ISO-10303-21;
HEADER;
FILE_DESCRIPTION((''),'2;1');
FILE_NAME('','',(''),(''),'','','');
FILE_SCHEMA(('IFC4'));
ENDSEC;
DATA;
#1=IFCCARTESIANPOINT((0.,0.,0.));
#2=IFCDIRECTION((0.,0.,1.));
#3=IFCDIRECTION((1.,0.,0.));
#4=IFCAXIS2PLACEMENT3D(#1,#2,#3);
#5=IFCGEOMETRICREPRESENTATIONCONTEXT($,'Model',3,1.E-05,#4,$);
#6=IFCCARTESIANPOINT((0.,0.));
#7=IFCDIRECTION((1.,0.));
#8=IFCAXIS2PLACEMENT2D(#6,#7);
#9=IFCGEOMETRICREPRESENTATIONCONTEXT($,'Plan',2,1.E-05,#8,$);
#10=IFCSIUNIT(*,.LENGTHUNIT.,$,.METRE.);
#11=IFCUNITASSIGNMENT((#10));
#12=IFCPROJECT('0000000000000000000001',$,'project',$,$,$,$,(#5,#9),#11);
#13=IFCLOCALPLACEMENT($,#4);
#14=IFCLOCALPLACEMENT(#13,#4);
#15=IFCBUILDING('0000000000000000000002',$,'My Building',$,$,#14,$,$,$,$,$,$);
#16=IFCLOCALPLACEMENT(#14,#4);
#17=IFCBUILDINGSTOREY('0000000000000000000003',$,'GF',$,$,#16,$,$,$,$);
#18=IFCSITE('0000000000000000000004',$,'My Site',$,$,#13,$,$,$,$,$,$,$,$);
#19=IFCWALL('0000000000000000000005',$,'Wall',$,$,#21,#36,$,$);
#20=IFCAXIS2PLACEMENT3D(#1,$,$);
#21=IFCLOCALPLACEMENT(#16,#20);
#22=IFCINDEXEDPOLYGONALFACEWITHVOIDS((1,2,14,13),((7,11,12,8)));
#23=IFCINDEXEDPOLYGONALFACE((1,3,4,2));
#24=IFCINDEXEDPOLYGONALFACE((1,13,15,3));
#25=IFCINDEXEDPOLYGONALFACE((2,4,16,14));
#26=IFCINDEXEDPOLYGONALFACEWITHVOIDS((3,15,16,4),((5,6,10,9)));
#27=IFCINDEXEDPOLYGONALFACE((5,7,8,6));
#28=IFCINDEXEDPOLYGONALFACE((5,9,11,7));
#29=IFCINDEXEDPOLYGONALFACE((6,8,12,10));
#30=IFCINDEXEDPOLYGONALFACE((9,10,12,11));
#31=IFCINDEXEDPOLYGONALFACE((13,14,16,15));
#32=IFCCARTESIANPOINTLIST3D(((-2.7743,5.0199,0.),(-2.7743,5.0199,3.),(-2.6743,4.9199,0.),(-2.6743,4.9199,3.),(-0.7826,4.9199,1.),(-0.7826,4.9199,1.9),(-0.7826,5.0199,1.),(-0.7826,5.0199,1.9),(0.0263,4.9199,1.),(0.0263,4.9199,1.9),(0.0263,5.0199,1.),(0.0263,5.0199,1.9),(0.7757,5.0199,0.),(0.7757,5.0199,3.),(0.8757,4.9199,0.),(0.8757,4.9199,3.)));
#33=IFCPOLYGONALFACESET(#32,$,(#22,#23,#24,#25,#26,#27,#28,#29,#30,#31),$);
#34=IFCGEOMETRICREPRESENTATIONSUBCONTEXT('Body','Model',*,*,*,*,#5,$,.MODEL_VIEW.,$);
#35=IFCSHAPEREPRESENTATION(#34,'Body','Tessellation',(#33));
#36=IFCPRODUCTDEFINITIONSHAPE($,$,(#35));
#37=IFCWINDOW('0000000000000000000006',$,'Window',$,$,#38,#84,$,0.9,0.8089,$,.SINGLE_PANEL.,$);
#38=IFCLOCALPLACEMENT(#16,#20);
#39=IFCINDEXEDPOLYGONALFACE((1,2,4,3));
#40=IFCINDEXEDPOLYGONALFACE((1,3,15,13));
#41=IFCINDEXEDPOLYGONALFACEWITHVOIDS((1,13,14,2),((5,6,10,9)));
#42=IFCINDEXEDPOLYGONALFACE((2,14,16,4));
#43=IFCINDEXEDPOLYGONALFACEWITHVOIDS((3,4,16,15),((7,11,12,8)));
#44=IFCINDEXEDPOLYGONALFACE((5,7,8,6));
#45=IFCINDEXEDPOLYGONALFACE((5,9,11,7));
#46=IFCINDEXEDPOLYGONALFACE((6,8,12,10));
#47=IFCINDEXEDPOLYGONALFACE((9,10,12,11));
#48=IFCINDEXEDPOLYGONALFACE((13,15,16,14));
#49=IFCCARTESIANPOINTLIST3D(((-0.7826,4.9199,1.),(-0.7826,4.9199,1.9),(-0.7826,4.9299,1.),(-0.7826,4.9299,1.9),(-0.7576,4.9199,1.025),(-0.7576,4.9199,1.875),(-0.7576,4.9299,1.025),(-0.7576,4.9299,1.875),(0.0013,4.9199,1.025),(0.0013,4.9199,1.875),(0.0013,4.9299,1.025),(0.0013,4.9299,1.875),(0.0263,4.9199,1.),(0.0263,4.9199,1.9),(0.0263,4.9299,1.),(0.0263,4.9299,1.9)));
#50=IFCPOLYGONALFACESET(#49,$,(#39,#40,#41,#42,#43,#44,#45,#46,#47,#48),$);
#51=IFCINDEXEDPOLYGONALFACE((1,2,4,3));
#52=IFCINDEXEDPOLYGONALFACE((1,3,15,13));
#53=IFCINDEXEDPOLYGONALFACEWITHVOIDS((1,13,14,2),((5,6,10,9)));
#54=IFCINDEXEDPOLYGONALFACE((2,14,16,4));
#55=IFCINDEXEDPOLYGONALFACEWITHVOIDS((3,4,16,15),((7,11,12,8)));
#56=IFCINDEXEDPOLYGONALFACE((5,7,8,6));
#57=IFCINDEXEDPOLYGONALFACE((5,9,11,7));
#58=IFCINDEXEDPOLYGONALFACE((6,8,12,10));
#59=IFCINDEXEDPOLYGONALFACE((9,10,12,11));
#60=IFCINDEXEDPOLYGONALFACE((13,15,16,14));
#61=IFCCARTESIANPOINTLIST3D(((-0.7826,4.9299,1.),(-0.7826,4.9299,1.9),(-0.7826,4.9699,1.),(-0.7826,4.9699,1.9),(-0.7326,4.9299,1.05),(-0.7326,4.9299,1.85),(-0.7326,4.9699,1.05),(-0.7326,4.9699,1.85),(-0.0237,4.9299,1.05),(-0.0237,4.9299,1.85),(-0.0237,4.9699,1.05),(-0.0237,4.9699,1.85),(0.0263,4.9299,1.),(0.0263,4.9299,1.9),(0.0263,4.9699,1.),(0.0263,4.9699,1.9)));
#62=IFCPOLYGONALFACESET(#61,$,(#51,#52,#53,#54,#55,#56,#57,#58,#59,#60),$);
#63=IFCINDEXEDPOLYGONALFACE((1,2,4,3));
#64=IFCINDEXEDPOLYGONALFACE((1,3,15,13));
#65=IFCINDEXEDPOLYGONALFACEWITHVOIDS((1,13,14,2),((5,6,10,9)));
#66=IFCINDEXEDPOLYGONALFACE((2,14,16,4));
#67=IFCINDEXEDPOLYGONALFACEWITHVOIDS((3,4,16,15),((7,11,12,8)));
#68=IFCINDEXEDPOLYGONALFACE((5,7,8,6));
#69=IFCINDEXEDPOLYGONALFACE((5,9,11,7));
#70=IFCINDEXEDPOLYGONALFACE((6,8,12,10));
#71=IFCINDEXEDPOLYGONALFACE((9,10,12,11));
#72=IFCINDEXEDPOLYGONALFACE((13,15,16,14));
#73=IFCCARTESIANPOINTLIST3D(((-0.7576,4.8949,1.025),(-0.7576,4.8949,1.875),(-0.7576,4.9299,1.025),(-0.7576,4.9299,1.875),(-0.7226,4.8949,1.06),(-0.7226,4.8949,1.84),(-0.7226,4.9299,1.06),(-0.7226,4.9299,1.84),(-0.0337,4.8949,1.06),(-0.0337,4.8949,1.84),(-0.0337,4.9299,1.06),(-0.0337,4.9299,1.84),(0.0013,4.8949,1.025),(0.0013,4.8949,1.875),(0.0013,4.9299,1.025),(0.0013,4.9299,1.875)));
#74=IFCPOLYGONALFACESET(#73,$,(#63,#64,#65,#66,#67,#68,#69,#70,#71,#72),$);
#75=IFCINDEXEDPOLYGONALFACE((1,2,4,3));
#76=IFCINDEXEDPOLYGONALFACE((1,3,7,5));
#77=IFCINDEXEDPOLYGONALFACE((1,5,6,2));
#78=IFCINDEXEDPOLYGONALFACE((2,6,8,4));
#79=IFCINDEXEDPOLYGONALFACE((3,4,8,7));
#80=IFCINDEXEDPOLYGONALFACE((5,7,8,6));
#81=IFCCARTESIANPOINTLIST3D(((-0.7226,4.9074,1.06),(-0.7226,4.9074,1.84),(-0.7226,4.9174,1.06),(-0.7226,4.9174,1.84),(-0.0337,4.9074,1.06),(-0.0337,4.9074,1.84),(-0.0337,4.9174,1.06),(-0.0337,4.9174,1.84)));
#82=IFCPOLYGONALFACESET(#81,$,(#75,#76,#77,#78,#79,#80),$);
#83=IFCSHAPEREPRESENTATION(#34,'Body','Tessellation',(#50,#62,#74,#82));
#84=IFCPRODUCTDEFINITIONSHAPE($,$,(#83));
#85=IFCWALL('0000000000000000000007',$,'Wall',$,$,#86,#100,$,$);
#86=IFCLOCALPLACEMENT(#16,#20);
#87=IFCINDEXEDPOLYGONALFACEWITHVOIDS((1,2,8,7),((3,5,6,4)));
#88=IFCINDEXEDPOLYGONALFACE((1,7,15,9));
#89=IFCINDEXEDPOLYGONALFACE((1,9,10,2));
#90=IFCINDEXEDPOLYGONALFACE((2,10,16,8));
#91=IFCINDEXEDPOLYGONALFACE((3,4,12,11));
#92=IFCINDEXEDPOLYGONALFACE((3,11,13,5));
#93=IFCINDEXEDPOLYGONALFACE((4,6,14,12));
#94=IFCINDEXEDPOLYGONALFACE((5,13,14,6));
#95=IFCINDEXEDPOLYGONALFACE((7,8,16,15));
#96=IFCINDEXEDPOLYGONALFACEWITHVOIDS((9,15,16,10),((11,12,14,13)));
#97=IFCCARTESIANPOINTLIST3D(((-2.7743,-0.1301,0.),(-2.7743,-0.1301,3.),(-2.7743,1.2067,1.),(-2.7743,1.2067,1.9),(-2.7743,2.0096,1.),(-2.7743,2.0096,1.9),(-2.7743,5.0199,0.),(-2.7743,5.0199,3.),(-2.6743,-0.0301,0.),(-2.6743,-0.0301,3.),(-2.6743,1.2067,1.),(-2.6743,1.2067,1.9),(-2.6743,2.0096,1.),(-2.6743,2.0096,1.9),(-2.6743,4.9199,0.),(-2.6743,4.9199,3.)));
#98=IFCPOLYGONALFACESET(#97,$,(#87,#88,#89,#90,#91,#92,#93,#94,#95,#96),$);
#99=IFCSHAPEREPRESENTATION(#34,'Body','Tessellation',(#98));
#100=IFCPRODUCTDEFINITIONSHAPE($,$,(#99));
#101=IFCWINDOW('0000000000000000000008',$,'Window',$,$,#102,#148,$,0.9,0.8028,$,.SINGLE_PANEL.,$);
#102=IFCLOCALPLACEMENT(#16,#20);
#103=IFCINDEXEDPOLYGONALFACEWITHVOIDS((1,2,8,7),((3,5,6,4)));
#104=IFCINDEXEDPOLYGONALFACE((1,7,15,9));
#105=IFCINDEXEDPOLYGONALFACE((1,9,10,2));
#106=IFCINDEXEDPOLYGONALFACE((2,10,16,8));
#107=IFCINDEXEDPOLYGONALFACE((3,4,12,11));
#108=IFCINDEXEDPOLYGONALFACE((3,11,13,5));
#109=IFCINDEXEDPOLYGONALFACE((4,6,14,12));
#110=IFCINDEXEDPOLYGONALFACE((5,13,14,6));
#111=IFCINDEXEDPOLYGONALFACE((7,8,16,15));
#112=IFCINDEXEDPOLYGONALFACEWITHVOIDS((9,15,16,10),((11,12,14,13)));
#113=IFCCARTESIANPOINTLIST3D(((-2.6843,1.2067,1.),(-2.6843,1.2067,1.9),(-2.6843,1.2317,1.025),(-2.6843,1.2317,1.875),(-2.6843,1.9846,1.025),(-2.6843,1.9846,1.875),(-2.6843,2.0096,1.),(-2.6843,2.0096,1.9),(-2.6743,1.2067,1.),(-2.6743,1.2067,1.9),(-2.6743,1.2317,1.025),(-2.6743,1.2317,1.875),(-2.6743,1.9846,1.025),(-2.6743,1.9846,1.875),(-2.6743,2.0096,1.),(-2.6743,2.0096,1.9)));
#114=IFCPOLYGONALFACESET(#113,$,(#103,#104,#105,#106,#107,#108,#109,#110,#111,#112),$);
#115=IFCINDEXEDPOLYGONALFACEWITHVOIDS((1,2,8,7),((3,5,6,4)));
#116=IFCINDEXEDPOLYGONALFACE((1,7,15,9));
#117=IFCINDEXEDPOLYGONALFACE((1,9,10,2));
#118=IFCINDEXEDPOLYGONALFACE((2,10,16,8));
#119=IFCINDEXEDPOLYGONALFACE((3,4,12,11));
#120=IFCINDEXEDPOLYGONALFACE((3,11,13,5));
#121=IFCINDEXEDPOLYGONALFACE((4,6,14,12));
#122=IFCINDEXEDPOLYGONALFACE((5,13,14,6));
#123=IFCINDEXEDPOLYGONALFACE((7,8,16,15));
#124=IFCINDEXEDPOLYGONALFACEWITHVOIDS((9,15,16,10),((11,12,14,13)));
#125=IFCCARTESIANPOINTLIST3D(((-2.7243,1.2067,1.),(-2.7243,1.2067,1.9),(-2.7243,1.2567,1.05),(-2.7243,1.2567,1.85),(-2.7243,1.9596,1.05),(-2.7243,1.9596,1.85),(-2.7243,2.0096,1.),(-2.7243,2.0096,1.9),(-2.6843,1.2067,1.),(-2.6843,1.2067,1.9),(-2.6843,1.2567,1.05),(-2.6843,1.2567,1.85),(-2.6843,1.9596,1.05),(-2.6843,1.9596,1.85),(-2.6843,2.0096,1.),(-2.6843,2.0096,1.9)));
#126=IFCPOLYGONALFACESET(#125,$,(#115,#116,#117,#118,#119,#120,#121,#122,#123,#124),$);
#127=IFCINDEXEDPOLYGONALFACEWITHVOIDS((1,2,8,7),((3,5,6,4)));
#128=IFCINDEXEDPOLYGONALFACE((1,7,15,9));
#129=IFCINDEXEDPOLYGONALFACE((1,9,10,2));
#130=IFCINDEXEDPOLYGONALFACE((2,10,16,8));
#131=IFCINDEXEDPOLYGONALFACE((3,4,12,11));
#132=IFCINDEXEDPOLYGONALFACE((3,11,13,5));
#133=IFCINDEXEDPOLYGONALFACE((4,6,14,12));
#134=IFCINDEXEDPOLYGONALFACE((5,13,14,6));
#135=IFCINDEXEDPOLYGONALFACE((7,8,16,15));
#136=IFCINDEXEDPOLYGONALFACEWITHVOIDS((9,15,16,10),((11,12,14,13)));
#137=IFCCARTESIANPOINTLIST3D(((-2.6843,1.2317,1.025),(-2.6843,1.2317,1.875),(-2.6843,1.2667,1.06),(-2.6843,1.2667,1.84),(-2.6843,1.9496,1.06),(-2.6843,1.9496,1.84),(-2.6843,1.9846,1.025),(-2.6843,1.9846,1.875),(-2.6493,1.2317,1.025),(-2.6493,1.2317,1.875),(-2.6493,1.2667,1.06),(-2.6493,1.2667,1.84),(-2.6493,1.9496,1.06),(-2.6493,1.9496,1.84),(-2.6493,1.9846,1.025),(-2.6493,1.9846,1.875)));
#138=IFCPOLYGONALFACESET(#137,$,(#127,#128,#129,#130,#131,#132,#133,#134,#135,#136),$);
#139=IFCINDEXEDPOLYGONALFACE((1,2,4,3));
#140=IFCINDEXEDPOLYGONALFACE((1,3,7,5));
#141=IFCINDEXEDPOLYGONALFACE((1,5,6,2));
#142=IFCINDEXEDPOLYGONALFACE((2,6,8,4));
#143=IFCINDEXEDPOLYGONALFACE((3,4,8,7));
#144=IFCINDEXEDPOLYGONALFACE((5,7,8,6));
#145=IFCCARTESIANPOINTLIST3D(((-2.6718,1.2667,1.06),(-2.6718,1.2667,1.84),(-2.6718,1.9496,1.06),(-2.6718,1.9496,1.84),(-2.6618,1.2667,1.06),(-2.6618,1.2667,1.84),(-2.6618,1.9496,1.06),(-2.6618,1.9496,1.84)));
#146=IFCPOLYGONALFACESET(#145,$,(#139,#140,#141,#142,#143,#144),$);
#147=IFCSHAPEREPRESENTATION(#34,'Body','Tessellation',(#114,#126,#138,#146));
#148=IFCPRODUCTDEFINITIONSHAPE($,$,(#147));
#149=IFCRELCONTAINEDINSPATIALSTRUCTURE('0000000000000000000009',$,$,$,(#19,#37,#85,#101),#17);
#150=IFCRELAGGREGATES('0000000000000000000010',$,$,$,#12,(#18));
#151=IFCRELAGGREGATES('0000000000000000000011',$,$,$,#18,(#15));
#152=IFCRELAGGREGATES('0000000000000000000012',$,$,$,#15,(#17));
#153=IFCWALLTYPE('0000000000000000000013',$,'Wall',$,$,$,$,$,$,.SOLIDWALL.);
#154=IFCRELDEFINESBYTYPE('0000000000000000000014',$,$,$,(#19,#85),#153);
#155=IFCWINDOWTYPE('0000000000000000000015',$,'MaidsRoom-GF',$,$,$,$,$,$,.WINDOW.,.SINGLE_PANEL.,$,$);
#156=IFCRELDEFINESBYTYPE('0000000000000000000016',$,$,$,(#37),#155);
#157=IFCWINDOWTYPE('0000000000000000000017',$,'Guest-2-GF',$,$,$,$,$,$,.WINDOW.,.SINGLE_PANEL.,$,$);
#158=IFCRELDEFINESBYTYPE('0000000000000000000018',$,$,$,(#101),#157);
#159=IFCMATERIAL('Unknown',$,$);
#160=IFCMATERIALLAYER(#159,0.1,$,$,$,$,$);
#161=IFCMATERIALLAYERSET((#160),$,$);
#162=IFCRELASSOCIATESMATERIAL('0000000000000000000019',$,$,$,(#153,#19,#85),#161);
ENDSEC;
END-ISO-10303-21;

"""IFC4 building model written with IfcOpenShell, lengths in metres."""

from ifc_helpers import new_model, entity, si_unit, frame, origin_with_axes, origin_2d_with_axis, place, context, subcontext, project, spatial, line, indexed_curve, outline, extrude, shape, source, transform, mapped, material, layer, layer_set, layer_usage, type_object, type_shapes, element, fill, save


model = new_model("IFC4")

# Units and contexts
model_context = context("Model", 3, precision=1e-05, world=origin_with_axes())
plan_context = context("Plan", 2, precision=1e-05, world=origin_2d_with_axis())
body_context_1 = subcontext(model_context, "Body", "Model", "MODEL_VIEW")
body_context_2 = subcontext(plan_context, "Body", "Plan", "PLAN_VIEW")
ifc_project = project(units=[si_unit("LENGTHUNIT", "METRE")], contexts=[model_context, plan_context])

# Site, building, storey
site_placement = place(None, origin_with_axes())
site = spatial("IfcSite", under=ifc_project, at=site_placement, Name="My Site")
building_placement = place(site_placement, origin_with_axes())
building = spatial("IfcBuilding", under=site, at=building_placement, Name="My Building")
storey_placement = place(building_placement, origin_with_axes())
storey = spatial("IfcBuildingStorey", under=building, at=storey_placement, Name="GF")

# Shared definitions
ifc_material_1 = material(Name="Unknown")

# Shared definitions
ifc_layer_1 = layer(ifc_material_1, 0.1)
ifc_layer_set_1 = layer_set([ifc_layer_1])
wall_type = type_object("IfcWallType", Name="Wall", PredefinedType="SOLIDWALL", material=ifc_layer_set_1)

# Walls, openings, windows
ifc_layer_usage_1 = layer_usage(ifc_layer_set_1, "AXIS2", "POSITIVE", 0.0)
wall_1_placement = place(storey_placement, frame((0.7757, 5.0199, 0.0), z_axis=(0.0, 0.0, 1.0), x_axis=(-1.0, 0.0, 0.0)))
wall_1 = element("IfcWall", 1, at=wall_1_placement, inside=storey, type_object=wall_type, material=ifc_layer_usage_1, Name="Wall", context=body_context_1, shape_type="SweptSolid", body=[
    extrude(outline(indexed_curve([(0.0, 0.0), (-0.1, 0.1), (3.45, 0.1), (3.55, 0.0)], segments=[line(1, 2, 3, 4, 1)])), origin_with_axes(), (0.0, 0.0, 1.0), 3.0),
])
shared_shape_1 = source(origin_with_axes(), body_context_1, "Body", "SweptSolid", [
    extrude(outline(indexed_curve([(0.0, 0.0), (0.8089, 0.0), (0.8089, 0.9), (0.0, 0.9)], segments=[line(1, 2, 3, 4, 1)])), frame((0.0, -0.6, 0.0), z_axis=(0.0, -1.0, 0.0), x_axis=(1.0, 0.0, 0.0)), (0.0, 0.0, -1.0), 1.2),
])
opening_1_placement = place(wall_1_placement, frame((0.7494, 0.0, 1.0), z_axis=(0.0, 0.0, 1.0), x_axis=(1.0, 0.0, 0.0)))
opening_1 = element("IfcOpeningElement", 2, at=opening_1_placement, cuts=wall_1, PredefinedType="OPENING", context=body_context_1, shape_type="MappedRepresentation", body=[
    mapped(shared_shape_1, transform((0.0, 0.0, 0.0), x_axis=(1.0, 0.0, 0.0), y_axis=(0.0, 1.0, 0.0), z_axis=(0.0, 0.0, 1.0), scale=1.0)),
])
window_type_1 = type_object("IfcWindowType", Name="MaidsRoom-GF", PartitioningType="SINGLE_PANEL", PredefinedType="WINDOW")
shared_shape_2 = source(origin_with_axes(), body_context_1, "Body", "SweptSolid", [
    extrude(outline(indexed_curve([(0.0, 0.0), (0.8089, 0.0), (0.8089, 0.9), (0.0, 0.9)], segments=[line(1, 2, 3, 4, 1)]), holes=[indexed_curve([(0.025, 0.025), (0.7839, 0.025), (0.7839, 0.875), (0.025, 0.875)], segments=[line(1, 2, 3, 4, 1)])]), frame((0.0, 0.09, 0.0), z_axis=(0.0, -1.0, 0.0), x_axis=(1.0, 0.0, 0.0)), (0.0, 0.0, -1.0), 0.01),
    extrude(outline(indexed_curve([(0.0, 0.0), (0.8089, 0.0), (0.8089, 0.9), (0.0, 0.9)], segments=[line(1, 2, 3, 4, 1)]), holes=[indexed_curve([(0.05, 0.05), (0.7589, 0.05), (0.7589, 0.85), (0.05, 0.85)], segments=[line(1, 2, 3, 4, 1)])]), frame((0.0, 0.05, 0.0), z_axis=(0.0, -1.0, 0.0), x_axis=(1.0, 0.0, 0.0)), (0.0, 0.0, -1.0), 0.04),
    extrude(outline(indexed_curve([(0.0, 0.0), (0.7589, 0.0), (0.7589, 0.85), (0.0, 0.85)], segments=[line(1, 2, 3, 4, 1)]), holes=[indexed_curve([(0.035, 0.035), (0.7239, 0.035), (0.7239, 0.815), (0.035, 0.815)], segments=[line(1, 2, 3, 4, 1)])]), frame((0.025, 0.09, 0.025), z_axis=(0.0, -1.0, 0.0), x_axis=(1.0, 0.0, 0.0)), (0.0, 0.0, -1.0), 0.035),
    extrude(outline(indexed_curve([(0.035, 0.035), (0.7239, 0.035), (0.7239, 0.815), (0.035, 0.815)], segments=[line(1, 2, 3, 4, 1)])), frame((0.025, 0.1025, 0.025), z_axis=(0.0, -1.0, 0.0), x_axis=(1.0, 0.0, 0.0)), (0.0, 0.0, -1.0), 0.01),
])
shared_shape_3 = source(origin_with_axes(), body_context_2, "Body", "Curve2D", [
    entity("IfcIndexedPolyCurve", entity("IfcCartesianPointList2D", [[0.05, 0.05], [0.7589, 0.05]])),
    entity("IfcIndexedPolyCurve", entity("IfcCartesianPointList2D", [[0.0, 0.1], [0.025, 0.1], [0.025, 0.09], [0.05, 0.09], [0.05, 0.05], [0.0, 0.05]]), [entity("IfcLineIndex", [1, 2, 3, 4, 5, 6, 1])]),
    entity("IfcIndexedPolyCurve", entity("IfcCartesianPointList2D", [[0.8089, 0.1], [0.7839, 0.1], [0.7839, 0.09], [0.7589, 0.09], [0.7589, 0.05], [0.8089, 0.05]]), [entity("IfcLineIndex", [1, 2, 3, 4, 5, 6, 1])]),
    entity("IfcIndexedPolyCurve", entity("IfcCartesianPointList2D", [[0.025, 0.09], [0.06, 0.09], [0.06, 0.125], [0.025, 0.125]]), [entity("IfcLineIndex", [1, 2, 3, 4, 1])]),
    entity("IfcIndexedPolyCurve", entity("IfcCartesianPointList2D", [[0.7839, 0.09], [0.7489, 0.09], [0.7489, 0.125], [0.7839, 0.125]]), [entity("IfcLineIndex", [1, 2, 3, 4, 1])]),
    entity("IfcIndexedPolyCurve", entity("IfcCartesianPointList2D", [[0.06, 0.09], [0.7489, 0.09]])),
    entity("IfcIndexedPolyCurve", entity("IfcCartesianPointList2D", [[0.06, 0.125], [0.7489, 0.125]])),
    entity("IfcIndexedPolyCurve", entity("IfcCartesianPointList2D", [[0.06, 0.1075], [0.7489, 0.1075]])),
])
type_shapes(window_type_1, [shared_shape_2, shared_shape_3])
window_1_placement = place(opening_1_placement, origin_with_axes())
window_1 = element("IfcWindow", 3, at=window_1_placement, inside=storey, type_object=window_type_1, Name="Window", OverallHeight=0.9, OverallWidth=0.8089, PartitioningType="SINGLE_PANEL", shapes=[
    shape(body_context_1, "Body", "MappedRepresentation", [mapped(shared_shape_2, transform((0.0, 0.0, 0.0), x_axis=(1.0, 0.0, 0.0), y_axis=(0.0, 1.0, 0.0), z_axis=(0.0, 0.0, 1.0), scale=1.0))]),
    shape(body_context_2, "Body", "MappedRepresentation", [mapped(shared_shape_3, transform((0.0, 0.0, 0.0), x_axis=(1.0, 0.0, 0.0), y_axis=(0.0, 1.0, 0.0), z_axis=(0.0, 0.0, 1.0), scale=1.0))]),
])
fill(opening_1, window_1)
ifc_layer_usage_2 = layer_usage(ifc_layer_set_1, "AXIS2", "POSITIVE", 0.0)
wall_2_placement = place(storey_placement, frame((-2.7743, 5.0199, 0.0), z_axis=(0.0, 0.0, 1.0), x_axis=(0.0, -1.0, 0.0)))
wall_2 = element("IfcWall", 4, at=wall_2_placement, inside=storey, type_object=wall_type, material=ifc_layer_usage_2, Name="Wall", context=body_context_1, shape_type="SweptSolid", body=[
    extrude(outline(indexed_curve([(0.0, 0.0), (0.1, 0.1), (5.05, 0.1), (5.15, 0.0)], segments=[line(1, 2, 3, 4, 1)])), origin_with_axes(), (0.0, 0.0, 1.0), 3.0),
])
shared_shape_4 = source(origin_with_axes(), body_context_1, "Body", "SweptSolid", [
    extrude(outline(indexed_curve([(0.0, 0.0), (0.8028, 0.0), (0.8028, 0.9), (0.0, 0.9)], segments=[line(1, 2, 3, 4, 1)])), frame((0.0, -0.6, 0.0), z_axis=(0.0, -1.0, 0.0), x_axis=(1.0, 0.0, 0.0)), (0.0, 0.0, -1.0), 1.2),
])
opening_2_placement = place(wall_2_placement, frame((3.0103, 0.0, 1.0), z_axis=(0.0, 0.0, 1.0), x_axis=(1.0, 0.0, 0.0)))
opening_2 = element("IfcOpeningElement", 5, at=opening_2_placement, cuts=wall_2, PredefinedType="OPENING", context=body_context_1, shape_type="MappedRepresentation", body=[
    mapped(shared_shape_4, transform((0.0, 0.0, 0.0), x_axis=(1.0, 0.0, 0.0), y_axis=(0.0, 1.0, 0.0), z_axis=(0.0, 0.0, 1.0), scale=1.0)),
])
window_type_2 = type_object("IfcWindowType", Name="Guest-2-GF", PartitioningType="SINGLE_PANEL", PredefinedType="WINDOW")
shared_shape_5 = source(origin_with_axes(), body_context_1, "Body", "SweptSolid", [
    extrude(outline(indexed_curve([(0.0, 0.0), (0.8028, 0.0), (0.8028, 0.9), (0.0, 0.9)], segments=[line(1, 2, 3, 4, 1)]), holes=[indexed_curve([(0.025, 0.025), (0.7778, 0.025), (0.7778, 0.875), (0.025, 0.875)], segments=[line(1, 2, 3, 4, 1)])]), frame((0.0, 0.09, 0.0), z_axis=(0.0, -1.0, 0.0), x_axis=(1.0, 0.0, 0.0)), (0.0, 0.0, -1.0), 0.01),
    extrude(outline(indexed_curve([(0.0, 0.0), (0.8028, 0.0), (0.8028, 0.9), (0.0, 0.9)], segments=[line(1, 2, 3, 4, 1)]), holes=[indexed_curve([(0.05, 0.05), (0.7528, 0.05), (0.7528, 0.85), (0.05, 0.85)], segments=[line(1, 2, 3, 4, 1)])]), frame((0.0, 0.05, 0.0), z_axis=(0.0, -1.0, 0.0), x_axis=(1.0, 0.0, 0.0)), (0.0, 0.0, -1.0), 0.04),
    extrude(outline(indexed_curve([(0.0, 0.0), (0.7528, 0.0), (0.7528, 0.85), (0.0, 0.85)], segments=[line(1, 2, 3, 4, 1)]), holes=[indexed_curve([(0.035, 0.035), (0.7178, 0.035), (0.7178, 0.815), (0.035, 0.815)], segments=[line(1, 2, 3, 4, 1)])]), frame((0.025, 0.09, 0.025), z_axis=(0.0, -1.0, 0.0), x_axis=(1.0, 0.0, 0.0)), (0.0, 0.0, -1.0), 0.035),
    extrude(outline(indexed_curve([(0.035, 0.035), (0.7178, 0.035), (0.7178, 0.815), (0.035, 0.815)], segments=[line(1, 2, 3, 4, 1)])), frame((0.025, 0.1025, 0.025), z_axis=(0.0, -1.0, 0.0), x_axis=(1.0, 0.0, 0.0)), (0.0, 0.0, -1.0), 0.01),
])
shared_shape_6 = source(origin_with_axes(), body_context_2, "Body", "Curve2D", [
    entity("IfcIndexedPolyCurve", entity("IfcCartesianPointList2D", [[0.05, 0.05], [0.7528, 0.05]])),
    entity("IfcIndexedPolyCurve", entity("IfcCartesianPointList2D", [[0.0, 0.1], [0.025, 0.1], [0.025, 0.09], [0.05, 0.09], [0.05, 0.05], [0.0, 0.05]]), [entity("IfcLineIndex", [1, 2, 3, 4, 5, 6, 1])]),
    entity("IfcIndexedPolyCurve", entity("IfcCartesianPointList2D", [[0.8028, 0.1], [0.7778, 0.1], [0.7778, 0.09], [0.7528, 0.09], [0.7528, 0.05], [0.8028, 0.05]]), [entity("IfcLineIndex", [1, 2, 3, 4, 5, 6, 1])]),
    entity("IfcIndexedPolyCurve", entity("IfcCartesianPointList2D", [[0.025, 0.09], [0.06, 0.09], [0.06, 0.125], [0.025, 0.125]]), [entity("IfcLineIndex", [1, 2, 3, 4, 1])]),
    entity("IfcIndexedPolyCurve", entity("IfcCartesianPointList2D", [[0.7778, 0.09], [0.7428, 0.09], [0.7428, 0.125], [0.7778, 0.125]]), [entity("IfcLineIndex", [1, 2, 3, 4, 1])]),
    entity("IfcIndexedPolyCurve", entity("IfcCartesianPointList2D", [[0.06, 0.09], [0.7428, 0.09]])),
    entity("IfcIndexedPolyCurve", entity("IfcCartesianPointList2D", [[0.06, 0.125], [0.7428, 0.125]])),
    entity("IfcIndexedPolyCurve", entity("IfcCartesianPointList2D", [[0.06, 0.1075], [0.7428, 0.1075]])),
])
type_shapes(window_type_2, [shared_shape_5, shared_shape_6])
window_2_placement = place(opening_2_placement, frame((0.0, 0.0, 0.0), z_axis=(0.0, 0.0, 1.0), x_axis=(1.0, 0.0, 0.0)))
window_2 = element("IfcWindow", 6, at=window_2_placement, inside=storey, type_object=window_type_2, Name="Window", OverallHeight=0.9, OverallWidth=0.8028, PartitioningType="SINGLE_PANEL", shapes=[
    shape(body_context_1, "Body", "MappedRepresentation", [mapped(shared_shape_5, transform((0.0, 0.0, 0.0), x_axis=(1.0, 0.0, 0.0), y_axis=(0.0, 1.0, 0.0), z_axis=(0.0, 0.0, 1.0), scale=1.0))]),
    shape(body_context_2, "Body", "MappedRepresentation", [mapped(shared_shape_6, transform((0.0, 0.0, 0.0), x_axis=(1.0, 0.0, 0.0), y_axis=(0.0, 1.0, 0.0), z_axis=(0.0, 0.0, 1.0), scale=1.0))]),
])
fill(opening_2, window_2)

save(model, "model.ifc")
